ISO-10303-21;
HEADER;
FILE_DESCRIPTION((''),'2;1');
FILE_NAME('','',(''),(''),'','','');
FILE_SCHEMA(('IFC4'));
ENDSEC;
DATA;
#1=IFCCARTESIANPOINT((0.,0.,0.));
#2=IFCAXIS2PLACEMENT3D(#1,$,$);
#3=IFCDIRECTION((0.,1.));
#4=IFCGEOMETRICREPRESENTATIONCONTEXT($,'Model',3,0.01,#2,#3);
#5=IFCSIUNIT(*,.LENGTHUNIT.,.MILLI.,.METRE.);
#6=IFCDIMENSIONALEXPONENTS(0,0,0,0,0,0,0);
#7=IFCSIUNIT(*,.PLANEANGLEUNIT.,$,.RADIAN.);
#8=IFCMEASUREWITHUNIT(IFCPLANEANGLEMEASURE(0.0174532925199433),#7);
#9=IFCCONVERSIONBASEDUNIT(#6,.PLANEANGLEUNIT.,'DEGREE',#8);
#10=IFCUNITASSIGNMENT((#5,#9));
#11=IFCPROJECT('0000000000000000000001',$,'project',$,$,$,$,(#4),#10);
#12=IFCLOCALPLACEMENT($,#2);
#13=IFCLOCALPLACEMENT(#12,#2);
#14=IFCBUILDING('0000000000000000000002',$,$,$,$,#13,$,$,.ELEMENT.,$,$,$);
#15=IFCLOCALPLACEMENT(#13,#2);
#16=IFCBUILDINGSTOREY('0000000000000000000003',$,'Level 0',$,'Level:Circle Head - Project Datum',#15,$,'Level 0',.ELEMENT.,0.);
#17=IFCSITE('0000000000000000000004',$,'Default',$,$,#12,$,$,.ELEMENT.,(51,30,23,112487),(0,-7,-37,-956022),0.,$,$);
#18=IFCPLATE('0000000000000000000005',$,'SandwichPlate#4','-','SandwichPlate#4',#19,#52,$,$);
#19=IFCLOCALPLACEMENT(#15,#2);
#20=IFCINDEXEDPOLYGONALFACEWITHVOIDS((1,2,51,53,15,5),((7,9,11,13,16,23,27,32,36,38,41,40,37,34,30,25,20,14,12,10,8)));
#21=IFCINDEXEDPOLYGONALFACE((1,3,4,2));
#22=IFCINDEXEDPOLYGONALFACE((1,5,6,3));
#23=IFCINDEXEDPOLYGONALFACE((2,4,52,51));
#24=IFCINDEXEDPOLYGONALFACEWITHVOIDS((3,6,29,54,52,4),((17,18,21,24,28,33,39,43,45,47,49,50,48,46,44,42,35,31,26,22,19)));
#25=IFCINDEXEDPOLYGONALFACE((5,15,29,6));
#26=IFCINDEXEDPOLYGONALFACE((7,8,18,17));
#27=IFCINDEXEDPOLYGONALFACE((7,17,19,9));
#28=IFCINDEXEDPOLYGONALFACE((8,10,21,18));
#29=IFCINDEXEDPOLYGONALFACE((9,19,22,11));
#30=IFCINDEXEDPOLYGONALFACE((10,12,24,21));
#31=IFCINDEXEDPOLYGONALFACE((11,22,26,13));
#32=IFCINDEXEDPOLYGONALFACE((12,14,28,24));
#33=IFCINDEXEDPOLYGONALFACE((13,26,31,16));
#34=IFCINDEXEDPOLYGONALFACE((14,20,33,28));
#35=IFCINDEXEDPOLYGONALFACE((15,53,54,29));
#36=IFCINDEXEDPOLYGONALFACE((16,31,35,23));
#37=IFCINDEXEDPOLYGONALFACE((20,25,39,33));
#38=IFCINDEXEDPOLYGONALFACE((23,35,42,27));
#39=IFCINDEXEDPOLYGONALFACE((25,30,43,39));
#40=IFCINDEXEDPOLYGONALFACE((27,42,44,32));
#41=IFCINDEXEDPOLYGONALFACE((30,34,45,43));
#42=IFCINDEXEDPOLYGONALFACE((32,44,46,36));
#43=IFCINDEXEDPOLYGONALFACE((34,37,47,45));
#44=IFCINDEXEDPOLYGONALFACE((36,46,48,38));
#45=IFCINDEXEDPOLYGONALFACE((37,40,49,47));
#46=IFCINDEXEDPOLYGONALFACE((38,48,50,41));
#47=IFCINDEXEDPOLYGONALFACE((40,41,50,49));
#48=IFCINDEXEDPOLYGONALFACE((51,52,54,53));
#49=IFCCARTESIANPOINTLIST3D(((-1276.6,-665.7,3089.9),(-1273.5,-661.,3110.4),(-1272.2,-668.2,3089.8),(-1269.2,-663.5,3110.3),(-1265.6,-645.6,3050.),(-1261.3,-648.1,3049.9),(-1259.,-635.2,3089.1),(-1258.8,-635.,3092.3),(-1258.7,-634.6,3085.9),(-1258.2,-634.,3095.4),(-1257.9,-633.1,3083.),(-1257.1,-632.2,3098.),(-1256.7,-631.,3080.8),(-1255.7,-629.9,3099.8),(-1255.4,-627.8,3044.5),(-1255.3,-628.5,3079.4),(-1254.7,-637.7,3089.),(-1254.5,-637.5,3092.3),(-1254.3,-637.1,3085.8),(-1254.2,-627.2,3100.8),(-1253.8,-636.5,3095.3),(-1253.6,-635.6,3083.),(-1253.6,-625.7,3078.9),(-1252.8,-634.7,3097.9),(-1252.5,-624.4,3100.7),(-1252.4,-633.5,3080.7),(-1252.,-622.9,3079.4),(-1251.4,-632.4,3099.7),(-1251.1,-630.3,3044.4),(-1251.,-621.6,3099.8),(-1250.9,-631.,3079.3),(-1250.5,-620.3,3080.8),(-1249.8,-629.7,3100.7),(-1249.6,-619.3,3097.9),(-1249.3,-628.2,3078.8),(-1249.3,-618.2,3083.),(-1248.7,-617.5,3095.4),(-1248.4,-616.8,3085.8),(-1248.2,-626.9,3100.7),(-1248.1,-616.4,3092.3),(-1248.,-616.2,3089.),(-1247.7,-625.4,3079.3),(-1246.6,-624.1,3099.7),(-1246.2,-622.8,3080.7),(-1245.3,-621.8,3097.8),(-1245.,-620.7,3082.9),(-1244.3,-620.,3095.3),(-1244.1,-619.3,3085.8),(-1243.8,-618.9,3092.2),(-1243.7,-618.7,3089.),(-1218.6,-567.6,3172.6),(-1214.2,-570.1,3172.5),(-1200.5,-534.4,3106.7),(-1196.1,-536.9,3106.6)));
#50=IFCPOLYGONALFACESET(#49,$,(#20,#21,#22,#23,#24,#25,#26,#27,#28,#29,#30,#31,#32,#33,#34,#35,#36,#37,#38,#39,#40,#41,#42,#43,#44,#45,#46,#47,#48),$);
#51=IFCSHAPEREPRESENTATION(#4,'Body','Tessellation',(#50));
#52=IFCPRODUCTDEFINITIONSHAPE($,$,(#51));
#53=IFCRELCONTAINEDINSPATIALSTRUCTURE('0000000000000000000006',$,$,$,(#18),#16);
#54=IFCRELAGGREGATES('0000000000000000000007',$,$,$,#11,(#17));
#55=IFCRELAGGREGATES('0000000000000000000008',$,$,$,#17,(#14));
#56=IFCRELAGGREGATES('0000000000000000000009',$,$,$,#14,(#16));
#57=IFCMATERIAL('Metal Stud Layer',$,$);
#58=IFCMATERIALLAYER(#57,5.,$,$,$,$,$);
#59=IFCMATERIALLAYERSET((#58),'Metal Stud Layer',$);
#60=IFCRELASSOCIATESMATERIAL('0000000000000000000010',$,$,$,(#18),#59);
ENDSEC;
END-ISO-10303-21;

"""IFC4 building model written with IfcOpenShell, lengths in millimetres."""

from ifc_helpers import new_model, entity, si_unit, converted_unit, direction, frame, origin, origin_with_axes, origin_2d_with_axis, place, context, project, spatial, polyline, circle, outline, extrude, material, layer, layer_set, element, save


model = new_model("IFC4")

# Units and contexts
model_context = context("Model", 3, precision=0.01, world=origin(), true_north=direction((0.0, 1.0)))
ifc_project = project(units=[si_unit("LENGTHUNIT", "METRE", prefix="MILLI"), converted_unit("PLANEANGLEUNIT", "DEGREE", entity("IfcPlaneAngleMeasure", 0.0174532925199433), si_unit("PLANEANGLEUNIT", "RADIAN"), dimensions=[0, 0, 0, 0, 0, 0, 0])], contexts=[model_context])

# Site, building, storey
site_placement = place(None, origin())
site = spatial("IfcSite", under=ifc_project, at=site_placement, Name="Default", CompositionType="ELEMENT", RefLatitude=(51, 30, 23, 112487), RefLongitude=(0, -7, -37, -956022), RefElevation=0.0)
building_placement = place(site_placement, origin())
building = spatial("IfcBuilding", under=site, at=building_placement, CompositionType="ELEMENT")
storey_placement = place(building_placement, origin())
storey = spatial("IfcBuildingStorey", under=building, at=storey_placement, Name="Level 0", ObjectType="Level:Circle Head - Project Datum", LongName="Level 0", CompositionType="ELEMENT", Elevation=0.0)

# Plate, openings
ifc_material = material(Name="Metal Stud Layer")
ifc_layer_1 = layer(ifc_material, 5.0)
ifc_layer_set_1 = layer_set([ifc_layer_1], Name="Metal Stud Layer")
plate_1_placement = place(storey_placement, frame((-1257.7, -641.5, 3036.9), z_axis=(-0.865935, 0.499948, 0.014432), x_axis=(-0.238139, -0.437501, 0.867112)))
plate_1 = element("IfcPlate", 1, at=plate_1_placement, inside=storey, material=ifc_layer_set_1, Name="SandwichPlate#4", Description="-", ObjectType="SandwichPlate#4", context=model_context, shape_type="SweptSolid", body=[
    extrude(outline(polyline([(0.0, 0.0), (76.0, 0.0), (76.0, 140.0), (0.0, 140.0), (0.0, 0.0)])), origin_with_axes(), (0.0, 0.0, 1.0), 5.0),
])
opening_1_placement = place(plate_1_placement, frame((0.0, 0.0, 0.0), z_axis=(0.0, 0.0, 1.0), x_axis=(1.0, 0.0, 0.0)))
element("IfcOpeningElement", 2, at=opening_1_placement, cuts=plate_1, ObjectType="Opening", context=model_context, shape_type="SweptSolid", body=[
    extrude(outline(polyline([(0.0, 0.0), (15.0, 0.0), (0.0, 15.0), (0.0, 0.0)])), origin(), (0.0, 0.0, 1.0), 5.0),
])
opening_2_placement = place(plate_1_placement, frame((0.0, 0.0, 0.0), z_axis=(0.0, 0.0, 1.0), x_axis=(1.0, 0.0, 0.0)))
element("IfcOpeningElement", 3, at=opening_2_placement, cuts=plate_1, ObjectType="Opening", context=model_context, shape_type="SweptSolid", body=[
    extrude(outline(polyline([(76.0, 0.0), (76.0, 15.0), (61.0, 0.0), (76.0, 0.0)])), origin(), (0.0, 0.0, 1.0), 5.0),
])
opening_3_placement = place(plate_1_placement, frame((38.0, 40.0, -0.5), z_axis=(0.0, 0.0, 1.0), x_axis=(0.0, 1.0, 0.0)))
element("IfcOpeningElement", 4, at=opening_3_placement, cuts=plate_1, ObjectType="Opening", context=model_context, shape_type="SweptSolid", body=[
    extrude(circle(Radius=11.0, at=origin_2d_with_axis()), origin(), (0.0, 0.0, 1.0), 6.0),
])

save(model, "model.ifc")
